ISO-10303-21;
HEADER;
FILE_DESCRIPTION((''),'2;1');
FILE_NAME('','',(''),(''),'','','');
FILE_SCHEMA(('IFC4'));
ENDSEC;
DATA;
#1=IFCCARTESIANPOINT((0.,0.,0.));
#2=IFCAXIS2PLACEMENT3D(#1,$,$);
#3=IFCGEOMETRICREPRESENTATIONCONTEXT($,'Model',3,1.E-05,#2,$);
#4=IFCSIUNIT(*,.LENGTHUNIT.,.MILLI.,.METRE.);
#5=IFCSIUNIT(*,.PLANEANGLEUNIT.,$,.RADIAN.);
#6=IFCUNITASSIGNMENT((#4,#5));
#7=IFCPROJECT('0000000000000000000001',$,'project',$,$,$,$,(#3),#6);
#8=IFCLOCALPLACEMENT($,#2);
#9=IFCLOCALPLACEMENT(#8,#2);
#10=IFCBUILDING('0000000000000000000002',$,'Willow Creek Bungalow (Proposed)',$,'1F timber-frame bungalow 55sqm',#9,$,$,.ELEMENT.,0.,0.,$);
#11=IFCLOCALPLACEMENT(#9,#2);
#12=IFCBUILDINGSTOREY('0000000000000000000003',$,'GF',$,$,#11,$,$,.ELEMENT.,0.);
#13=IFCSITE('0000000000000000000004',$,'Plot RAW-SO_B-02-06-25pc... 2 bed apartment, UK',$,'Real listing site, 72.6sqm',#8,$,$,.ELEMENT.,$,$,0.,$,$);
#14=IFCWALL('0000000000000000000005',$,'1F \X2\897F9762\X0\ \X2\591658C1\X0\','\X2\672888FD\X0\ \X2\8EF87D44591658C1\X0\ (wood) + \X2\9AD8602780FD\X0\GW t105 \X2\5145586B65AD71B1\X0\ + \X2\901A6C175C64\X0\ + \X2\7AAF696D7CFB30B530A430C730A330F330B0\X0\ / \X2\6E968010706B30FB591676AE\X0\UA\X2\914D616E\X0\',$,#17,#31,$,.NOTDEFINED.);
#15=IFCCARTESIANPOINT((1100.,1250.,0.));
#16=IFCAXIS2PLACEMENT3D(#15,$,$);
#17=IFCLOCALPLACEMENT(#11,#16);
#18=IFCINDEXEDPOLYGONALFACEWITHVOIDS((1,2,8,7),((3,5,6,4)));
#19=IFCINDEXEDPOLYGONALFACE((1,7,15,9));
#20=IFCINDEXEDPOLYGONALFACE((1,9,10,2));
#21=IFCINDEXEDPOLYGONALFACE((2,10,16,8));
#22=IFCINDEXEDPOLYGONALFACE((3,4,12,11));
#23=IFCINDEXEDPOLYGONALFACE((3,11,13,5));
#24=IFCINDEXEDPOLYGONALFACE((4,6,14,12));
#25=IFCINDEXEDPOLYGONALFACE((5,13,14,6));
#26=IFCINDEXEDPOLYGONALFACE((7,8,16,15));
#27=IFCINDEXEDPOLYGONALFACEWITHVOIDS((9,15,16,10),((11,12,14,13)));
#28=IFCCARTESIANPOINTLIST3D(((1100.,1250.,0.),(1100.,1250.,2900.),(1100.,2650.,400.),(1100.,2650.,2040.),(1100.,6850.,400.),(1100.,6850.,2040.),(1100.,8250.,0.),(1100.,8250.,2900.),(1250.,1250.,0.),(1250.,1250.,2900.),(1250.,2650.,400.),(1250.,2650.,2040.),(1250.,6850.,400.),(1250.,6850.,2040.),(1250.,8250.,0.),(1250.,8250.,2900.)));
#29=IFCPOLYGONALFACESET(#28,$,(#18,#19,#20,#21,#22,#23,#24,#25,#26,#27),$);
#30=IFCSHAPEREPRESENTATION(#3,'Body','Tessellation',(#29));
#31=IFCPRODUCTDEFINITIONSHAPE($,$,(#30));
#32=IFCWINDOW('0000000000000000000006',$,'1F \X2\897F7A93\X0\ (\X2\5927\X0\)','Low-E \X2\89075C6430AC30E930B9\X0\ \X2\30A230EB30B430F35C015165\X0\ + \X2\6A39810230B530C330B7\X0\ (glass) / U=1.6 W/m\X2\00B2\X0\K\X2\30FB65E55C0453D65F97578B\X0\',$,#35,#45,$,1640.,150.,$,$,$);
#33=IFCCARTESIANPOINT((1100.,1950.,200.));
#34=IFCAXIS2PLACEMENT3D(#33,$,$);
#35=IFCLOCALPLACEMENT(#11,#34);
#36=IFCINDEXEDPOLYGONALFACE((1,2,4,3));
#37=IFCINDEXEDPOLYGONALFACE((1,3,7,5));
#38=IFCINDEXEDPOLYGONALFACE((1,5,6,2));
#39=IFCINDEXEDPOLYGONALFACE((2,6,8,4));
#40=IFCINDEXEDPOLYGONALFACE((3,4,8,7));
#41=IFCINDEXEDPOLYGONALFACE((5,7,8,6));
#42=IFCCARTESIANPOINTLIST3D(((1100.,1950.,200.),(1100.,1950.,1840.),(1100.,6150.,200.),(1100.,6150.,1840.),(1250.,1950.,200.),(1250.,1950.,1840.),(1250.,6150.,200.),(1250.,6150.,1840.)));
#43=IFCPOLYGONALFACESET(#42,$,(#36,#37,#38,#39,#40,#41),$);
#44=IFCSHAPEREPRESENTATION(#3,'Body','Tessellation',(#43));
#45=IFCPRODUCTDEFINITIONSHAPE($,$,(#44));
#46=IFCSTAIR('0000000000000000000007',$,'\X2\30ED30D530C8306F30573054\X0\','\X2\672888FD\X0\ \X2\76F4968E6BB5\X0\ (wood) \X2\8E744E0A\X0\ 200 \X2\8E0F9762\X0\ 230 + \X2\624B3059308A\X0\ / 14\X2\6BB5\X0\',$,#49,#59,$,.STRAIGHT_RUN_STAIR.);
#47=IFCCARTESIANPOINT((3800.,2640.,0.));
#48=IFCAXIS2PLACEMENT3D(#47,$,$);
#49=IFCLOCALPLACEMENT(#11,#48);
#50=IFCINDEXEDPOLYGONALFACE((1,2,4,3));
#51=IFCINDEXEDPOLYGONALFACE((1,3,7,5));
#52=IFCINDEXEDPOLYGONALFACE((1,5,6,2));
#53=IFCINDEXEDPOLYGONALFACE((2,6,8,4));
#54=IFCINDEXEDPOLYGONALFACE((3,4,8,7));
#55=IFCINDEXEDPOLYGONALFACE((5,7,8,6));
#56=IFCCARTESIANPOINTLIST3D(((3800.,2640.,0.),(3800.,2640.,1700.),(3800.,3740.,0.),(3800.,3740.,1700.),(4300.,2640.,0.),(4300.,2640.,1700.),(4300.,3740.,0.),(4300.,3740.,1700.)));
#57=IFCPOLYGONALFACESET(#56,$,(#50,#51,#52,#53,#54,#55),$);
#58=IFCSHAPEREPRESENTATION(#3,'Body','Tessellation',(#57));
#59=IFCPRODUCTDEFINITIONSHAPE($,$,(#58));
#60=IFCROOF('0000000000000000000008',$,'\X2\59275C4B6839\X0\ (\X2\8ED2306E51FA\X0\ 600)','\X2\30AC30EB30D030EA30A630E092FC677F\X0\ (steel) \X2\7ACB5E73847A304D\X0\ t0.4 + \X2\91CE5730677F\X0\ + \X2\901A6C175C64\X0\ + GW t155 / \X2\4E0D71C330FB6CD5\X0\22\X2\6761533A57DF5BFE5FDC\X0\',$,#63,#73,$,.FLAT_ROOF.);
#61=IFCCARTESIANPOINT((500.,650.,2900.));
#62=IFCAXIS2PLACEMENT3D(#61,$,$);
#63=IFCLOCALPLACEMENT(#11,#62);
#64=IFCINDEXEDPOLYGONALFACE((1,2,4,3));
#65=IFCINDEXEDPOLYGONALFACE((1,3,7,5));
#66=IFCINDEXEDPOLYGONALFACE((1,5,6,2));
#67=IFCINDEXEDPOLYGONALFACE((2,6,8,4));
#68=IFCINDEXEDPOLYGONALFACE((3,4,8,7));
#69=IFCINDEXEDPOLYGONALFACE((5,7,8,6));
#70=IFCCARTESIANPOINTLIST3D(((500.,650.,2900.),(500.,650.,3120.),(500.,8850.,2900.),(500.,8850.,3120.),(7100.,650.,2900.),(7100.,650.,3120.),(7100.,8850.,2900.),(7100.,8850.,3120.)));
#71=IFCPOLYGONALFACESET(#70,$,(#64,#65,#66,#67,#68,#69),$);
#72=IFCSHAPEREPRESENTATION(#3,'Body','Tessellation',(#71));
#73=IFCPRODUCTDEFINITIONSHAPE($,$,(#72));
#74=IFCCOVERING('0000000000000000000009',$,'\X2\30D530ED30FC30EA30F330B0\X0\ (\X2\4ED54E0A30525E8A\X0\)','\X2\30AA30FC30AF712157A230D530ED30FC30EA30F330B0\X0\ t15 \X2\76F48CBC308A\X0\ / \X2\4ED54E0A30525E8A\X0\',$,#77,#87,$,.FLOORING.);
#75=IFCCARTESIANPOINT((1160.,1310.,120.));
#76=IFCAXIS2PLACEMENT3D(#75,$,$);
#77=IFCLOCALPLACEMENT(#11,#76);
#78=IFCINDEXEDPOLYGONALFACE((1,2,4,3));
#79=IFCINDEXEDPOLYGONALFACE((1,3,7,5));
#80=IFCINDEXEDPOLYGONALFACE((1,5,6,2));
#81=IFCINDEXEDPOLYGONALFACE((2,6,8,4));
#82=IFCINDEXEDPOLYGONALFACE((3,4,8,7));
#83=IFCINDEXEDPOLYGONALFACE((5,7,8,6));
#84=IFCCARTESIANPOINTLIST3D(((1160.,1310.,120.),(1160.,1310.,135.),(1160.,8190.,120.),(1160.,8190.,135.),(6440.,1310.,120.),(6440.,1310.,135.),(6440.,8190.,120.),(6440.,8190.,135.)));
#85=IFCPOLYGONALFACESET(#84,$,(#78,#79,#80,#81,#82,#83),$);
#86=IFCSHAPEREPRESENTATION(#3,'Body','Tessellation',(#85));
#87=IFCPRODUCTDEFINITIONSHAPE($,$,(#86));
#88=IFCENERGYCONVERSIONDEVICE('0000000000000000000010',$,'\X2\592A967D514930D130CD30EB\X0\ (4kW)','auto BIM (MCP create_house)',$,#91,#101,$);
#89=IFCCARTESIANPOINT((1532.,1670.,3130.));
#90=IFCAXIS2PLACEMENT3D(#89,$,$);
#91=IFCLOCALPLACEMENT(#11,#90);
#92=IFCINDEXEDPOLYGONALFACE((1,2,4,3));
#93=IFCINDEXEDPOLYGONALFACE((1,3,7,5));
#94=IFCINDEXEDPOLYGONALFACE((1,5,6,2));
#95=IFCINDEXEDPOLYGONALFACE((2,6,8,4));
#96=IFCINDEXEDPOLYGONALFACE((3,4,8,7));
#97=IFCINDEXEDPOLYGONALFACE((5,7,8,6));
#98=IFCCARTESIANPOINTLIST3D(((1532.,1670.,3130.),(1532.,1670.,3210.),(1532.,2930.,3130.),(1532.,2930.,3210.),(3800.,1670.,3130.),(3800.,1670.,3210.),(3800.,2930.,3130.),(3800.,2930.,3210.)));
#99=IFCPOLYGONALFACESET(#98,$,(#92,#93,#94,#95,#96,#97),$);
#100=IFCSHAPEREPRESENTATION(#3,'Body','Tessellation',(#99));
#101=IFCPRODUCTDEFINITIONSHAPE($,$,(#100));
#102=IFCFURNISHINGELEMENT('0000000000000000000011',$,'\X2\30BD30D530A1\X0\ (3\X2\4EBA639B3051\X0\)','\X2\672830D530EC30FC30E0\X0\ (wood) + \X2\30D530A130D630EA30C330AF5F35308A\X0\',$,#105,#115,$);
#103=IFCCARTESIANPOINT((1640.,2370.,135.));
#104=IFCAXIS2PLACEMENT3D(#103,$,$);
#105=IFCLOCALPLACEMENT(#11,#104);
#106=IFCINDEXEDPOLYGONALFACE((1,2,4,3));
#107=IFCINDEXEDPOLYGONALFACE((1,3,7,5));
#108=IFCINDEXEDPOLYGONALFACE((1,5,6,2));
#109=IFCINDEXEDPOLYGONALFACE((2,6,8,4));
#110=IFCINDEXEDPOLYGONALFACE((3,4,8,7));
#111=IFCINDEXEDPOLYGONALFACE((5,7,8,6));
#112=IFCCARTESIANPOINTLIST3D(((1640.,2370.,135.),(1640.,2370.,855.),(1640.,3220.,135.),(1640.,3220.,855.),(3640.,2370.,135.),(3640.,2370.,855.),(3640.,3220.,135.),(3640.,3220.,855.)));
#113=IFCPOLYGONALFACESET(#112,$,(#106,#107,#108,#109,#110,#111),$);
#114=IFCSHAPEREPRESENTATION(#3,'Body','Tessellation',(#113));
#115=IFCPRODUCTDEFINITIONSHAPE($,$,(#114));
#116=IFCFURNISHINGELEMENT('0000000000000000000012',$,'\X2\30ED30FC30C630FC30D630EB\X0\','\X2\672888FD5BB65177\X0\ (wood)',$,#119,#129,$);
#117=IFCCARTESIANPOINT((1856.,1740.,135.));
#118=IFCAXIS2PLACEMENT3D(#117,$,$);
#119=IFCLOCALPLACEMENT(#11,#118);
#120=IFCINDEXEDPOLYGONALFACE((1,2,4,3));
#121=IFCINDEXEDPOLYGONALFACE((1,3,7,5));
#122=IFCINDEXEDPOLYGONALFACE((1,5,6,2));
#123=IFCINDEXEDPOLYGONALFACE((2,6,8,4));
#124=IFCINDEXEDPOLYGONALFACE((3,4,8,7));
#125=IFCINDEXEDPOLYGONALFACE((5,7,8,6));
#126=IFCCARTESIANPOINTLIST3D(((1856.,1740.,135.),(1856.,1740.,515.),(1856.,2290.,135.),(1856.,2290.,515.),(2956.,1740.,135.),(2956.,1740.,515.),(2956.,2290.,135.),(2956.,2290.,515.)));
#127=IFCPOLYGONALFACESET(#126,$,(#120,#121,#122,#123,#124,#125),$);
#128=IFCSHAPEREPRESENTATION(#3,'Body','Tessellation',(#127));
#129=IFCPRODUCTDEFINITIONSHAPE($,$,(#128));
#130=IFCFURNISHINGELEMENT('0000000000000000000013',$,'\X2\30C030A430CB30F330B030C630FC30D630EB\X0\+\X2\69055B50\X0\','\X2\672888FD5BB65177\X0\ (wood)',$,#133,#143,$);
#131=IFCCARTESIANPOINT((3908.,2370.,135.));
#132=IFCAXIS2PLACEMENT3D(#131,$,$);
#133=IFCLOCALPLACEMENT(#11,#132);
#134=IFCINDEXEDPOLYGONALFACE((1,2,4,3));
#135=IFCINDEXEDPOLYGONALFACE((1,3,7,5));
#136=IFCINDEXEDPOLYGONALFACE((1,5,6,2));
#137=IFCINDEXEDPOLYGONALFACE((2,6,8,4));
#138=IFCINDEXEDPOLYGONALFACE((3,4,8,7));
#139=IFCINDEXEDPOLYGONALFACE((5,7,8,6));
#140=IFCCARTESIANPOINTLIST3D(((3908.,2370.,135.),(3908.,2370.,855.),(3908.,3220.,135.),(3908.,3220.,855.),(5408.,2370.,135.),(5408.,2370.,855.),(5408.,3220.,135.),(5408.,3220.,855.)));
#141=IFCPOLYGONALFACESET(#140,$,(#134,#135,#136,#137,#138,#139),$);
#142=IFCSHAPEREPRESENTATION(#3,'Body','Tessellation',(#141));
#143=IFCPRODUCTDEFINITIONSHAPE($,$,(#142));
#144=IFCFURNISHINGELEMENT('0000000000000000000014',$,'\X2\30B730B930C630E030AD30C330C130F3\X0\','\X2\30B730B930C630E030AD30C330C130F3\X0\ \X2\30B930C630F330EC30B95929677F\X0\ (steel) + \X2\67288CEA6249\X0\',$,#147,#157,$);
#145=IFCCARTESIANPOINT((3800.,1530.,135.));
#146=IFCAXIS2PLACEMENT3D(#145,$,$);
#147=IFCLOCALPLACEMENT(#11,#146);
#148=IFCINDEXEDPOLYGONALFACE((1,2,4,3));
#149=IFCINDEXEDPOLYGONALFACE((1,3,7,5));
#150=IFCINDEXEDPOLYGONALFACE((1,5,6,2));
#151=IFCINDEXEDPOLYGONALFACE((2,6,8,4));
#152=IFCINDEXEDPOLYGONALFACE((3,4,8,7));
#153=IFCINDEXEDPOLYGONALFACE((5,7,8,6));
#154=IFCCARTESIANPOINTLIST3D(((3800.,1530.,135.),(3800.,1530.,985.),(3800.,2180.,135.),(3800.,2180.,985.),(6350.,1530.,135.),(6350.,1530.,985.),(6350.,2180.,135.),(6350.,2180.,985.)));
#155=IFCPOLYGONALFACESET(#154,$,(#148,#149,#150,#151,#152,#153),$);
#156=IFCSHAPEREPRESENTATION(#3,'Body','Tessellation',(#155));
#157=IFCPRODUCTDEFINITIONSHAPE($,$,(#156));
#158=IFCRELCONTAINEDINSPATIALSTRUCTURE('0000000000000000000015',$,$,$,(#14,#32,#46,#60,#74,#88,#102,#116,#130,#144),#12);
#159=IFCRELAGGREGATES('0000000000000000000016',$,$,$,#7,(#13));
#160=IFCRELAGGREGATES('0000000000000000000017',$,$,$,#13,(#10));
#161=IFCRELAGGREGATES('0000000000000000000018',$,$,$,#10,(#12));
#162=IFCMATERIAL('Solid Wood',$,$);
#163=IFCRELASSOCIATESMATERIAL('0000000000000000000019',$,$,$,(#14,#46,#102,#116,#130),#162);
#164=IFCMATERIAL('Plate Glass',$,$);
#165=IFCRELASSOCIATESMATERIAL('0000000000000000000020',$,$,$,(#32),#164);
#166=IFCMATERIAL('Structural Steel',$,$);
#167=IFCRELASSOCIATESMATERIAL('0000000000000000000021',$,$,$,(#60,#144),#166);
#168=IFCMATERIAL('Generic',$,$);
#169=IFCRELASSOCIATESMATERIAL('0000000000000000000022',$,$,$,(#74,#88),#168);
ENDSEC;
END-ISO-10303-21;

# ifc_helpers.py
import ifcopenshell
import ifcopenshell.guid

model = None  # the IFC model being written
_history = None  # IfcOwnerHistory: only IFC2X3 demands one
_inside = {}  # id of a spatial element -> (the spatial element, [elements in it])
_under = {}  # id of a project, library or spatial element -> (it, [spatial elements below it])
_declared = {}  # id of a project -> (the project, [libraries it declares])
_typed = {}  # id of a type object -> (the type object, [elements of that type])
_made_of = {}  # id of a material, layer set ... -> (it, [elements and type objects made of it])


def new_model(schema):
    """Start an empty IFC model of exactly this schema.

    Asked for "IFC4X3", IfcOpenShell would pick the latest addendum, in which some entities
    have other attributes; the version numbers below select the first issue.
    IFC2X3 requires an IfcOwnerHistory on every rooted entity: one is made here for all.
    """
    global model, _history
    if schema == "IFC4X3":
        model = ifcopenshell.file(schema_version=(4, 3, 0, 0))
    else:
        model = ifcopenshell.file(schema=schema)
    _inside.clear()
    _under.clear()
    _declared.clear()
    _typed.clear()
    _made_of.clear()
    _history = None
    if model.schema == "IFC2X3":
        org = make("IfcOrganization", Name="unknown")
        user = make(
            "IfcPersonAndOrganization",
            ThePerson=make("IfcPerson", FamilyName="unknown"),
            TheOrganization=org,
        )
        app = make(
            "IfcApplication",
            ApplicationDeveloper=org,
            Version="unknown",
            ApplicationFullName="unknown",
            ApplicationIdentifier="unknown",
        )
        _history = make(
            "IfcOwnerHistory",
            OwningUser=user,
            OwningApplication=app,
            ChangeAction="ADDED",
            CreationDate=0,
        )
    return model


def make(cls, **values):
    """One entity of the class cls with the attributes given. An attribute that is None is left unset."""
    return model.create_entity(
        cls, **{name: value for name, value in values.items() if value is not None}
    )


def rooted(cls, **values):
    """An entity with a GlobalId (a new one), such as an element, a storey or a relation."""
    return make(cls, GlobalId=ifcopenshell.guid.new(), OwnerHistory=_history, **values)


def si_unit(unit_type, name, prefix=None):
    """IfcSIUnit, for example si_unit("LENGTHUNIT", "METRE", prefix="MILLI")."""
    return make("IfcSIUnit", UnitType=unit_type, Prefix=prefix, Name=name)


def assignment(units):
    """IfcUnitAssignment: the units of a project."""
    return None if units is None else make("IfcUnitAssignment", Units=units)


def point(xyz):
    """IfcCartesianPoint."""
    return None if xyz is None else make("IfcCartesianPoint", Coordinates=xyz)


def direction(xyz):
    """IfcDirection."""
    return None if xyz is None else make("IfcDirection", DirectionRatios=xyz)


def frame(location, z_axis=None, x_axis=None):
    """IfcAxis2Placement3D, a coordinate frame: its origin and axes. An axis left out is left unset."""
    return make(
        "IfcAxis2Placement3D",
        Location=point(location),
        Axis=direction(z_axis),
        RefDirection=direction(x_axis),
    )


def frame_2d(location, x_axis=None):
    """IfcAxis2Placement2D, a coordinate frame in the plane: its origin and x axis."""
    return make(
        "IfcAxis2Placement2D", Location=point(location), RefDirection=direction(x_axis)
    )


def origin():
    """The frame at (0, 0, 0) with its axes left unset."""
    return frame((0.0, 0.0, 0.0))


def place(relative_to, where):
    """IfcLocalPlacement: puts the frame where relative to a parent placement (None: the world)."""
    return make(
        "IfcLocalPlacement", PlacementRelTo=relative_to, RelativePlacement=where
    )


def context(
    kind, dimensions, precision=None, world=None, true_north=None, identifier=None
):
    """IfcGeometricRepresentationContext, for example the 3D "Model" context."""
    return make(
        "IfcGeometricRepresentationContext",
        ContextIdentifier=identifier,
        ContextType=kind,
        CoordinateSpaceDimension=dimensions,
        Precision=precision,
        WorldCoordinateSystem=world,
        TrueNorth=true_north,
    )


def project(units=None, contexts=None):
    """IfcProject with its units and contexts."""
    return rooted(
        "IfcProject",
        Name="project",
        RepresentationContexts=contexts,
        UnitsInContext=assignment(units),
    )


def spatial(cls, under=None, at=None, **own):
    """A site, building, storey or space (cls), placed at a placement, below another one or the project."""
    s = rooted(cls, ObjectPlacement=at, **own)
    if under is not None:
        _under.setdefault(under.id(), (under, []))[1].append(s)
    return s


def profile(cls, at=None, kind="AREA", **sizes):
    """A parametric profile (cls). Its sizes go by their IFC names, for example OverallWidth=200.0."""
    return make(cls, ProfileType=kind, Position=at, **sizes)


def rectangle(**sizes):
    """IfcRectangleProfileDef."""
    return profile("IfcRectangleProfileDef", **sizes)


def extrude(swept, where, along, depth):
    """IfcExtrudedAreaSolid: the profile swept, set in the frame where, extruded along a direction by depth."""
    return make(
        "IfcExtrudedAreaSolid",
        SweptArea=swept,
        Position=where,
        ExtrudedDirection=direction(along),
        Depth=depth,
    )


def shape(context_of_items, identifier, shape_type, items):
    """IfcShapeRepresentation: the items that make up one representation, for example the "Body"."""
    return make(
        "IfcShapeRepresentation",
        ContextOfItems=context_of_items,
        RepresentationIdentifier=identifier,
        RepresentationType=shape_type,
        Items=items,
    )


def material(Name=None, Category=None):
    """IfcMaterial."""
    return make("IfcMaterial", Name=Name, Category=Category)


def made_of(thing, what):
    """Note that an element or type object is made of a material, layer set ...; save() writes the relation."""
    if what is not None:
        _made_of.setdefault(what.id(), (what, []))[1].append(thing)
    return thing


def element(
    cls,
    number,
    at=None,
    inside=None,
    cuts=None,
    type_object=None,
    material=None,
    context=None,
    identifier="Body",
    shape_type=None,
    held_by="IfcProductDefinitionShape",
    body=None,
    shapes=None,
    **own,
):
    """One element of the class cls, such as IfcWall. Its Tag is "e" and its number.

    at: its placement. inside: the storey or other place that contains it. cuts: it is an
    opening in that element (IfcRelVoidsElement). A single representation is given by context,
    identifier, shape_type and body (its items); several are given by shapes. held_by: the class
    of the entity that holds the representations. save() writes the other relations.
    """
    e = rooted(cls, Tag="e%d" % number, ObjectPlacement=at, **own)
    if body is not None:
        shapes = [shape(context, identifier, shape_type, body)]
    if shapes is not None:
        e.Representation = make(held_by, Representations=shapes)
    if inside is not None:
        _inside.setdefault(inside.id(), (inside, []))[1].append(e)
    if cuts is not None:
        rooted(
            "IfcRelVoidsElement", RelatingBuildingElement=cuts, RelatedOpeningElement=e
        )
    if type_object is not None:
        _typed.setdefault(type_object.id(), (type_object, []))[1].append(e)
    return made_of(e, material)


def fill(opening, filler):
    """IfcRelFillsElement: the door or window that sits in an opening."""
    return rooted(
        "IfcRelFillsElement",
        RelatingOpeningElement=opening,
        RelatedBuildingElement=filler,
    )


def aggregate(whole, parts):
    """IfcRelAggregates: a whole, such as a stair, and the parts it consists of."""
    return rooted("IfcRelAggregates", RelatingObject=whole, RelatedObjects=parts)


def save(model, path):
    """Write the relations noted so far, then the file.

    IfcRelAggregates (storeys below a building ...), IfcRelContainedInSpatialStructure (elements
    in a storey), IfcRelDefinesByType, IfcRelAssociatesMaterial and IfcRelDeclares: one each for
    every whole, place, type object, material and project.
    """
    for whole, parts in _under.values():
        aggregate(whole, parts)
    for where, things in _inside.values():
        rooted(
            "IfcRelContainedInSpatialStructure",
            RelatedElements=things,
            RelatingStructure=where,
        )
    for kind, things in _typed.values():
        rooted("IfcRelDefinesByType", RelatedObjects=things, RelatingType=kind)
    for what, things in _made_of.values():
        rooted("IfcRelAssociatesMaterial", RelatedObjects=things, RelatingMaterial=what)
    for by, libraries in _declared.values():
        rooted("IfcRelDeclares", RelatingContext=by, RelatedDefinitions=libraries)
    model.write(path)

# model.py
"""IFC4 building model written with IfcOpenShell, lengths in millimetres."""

from ifc_helpers import new_model, si_unit, frame, frame_2d, origin, place, context, project, spatial, rectangle, extrude, material, element, fill, save


model = new_model("IFC4")

# Units and contexts
model_context = context("Model", 3, precision=1e-05, world=origin())
ifc_project = project(units=[si_unit("LENGTHUNIT", "METRE", prefix="MILLI"), si_unit("PLANEANGLEUNIT", "RADIAN")], contexts=[model_context])

# Site, building, storey
site_placement = place(None, origin())
site = spatial("IfcSite", under=ifc_project, at=site_placement, Name="Plot RAW-SO_B-02-06-25pc... 2 bed apartment, UK", ObjectType="Real listing site, 72.6sqm", CompositionType="ELEMENT", RefElevation=0.0)
building_placement = place(site_placement, origin())
building = spatial("IfcBuilding", under=site, at=building_placement, Name="Willow Creek Bungalow (Proposed)", ObjectType="1F timber-frame bungalow 55sqm", CompositionType="ELEMENT", ElevationOfRefHeight=0.0, ElevationOfTerrain=0.0)
storey_placement = place(building_placement, origin())
storey = spatial("IfcBuildingStorey", under=building, at=storey_placement, Name="GF", CompositionType="ELEMENT", Elevation=0.0)

# Shared definitions
ifc_material_1 = material(Name="Solid Wood")
ifc_material_2 = material(Name="Generic")

# Shared definitions
ifc_material_3 = material(Name="Plate Glass")

# Wall, opening, window
wall_1_placement = place(storey_placement, frame((1100.0, 1250.0, 0.0)))
wall_1 = element("IfcWall", 1, at=wall_1_placement, inside=storey, material=ifc_material_1, Name="1F 西面 外壁", Description="木製 軸組外壁 (wood) + 高性能GW t105 充填断熱 + 通気層 + 窯業系サイディング / 準耐火・外皮UA配慮", PredefinedType="NOTDEFINED", context=model_context, shape_type="SweptSolid", body=[
    extrude(rectangle(XDim=150.0, YDim=7000.0, at=frame_2d((75.0, 3500.0))), frame((1100.0, 1250.0, 0.0)), (0.0, 0.0, 1.0), 2900.0),
])
opening_1_placement = place(storey_placement, frame((1100.0, 1950.0, 200.0)))
opening_1 = element("IfcOpeningElement", 2, at=opening_1_placement, cuts=wall_1, PredefinedType="NOTDEFINED", context=model_context, shape_type="SweptSolid", body=[
    extrude(rectangle(XDim=150.0, YDim=4200.0, at=frame_2d((75.0, 2100.0))), frame((1100.0, 1950.0, 200.0)), (0.0, 0.0, 1.0), 1640.0),
])
window_1_placement = place(storey_placement, frame((1100.0, 1950.0, 200.0)))
window_1 = element("IfcWindow", 3, at=window_1_placement, inside=storey, material=ifc_material_3, Name="1F 西窓 (大)", Description="Low-E 複層ガラス アルゴン封入 + 樹脂サッシ (glass) / U=1.6 W/m²K・日射取得型", OverallHeight=1640.0, OverallWidth=150.0, context=model_context, shape_type="SweptSolid", body=[
    extrude(rectangle(XDim=150.0, YDim=4200.0, at=frame_2d((75.0, 2100.0))), frame((1100.0, 1950.0, 200.0)), (0.0, 0.0, 1.0), 1640.0),
])
fill(opening_1, window_1)

# Stair
stair_placement = place(storey_placement, frame((3800.0, 2640.0, 0.0)))
element("IfcStair", 4, at=stair_placement, inside=storey, material=ifc_material_1, Name="ロフトはしご", Description="木製 直階段 (wood) 蹴上 200 踏面 230 + 手すり / 14段", PredefinedType="STRAIGHT_RUN_STAIR", context=model_context, shape_type="SweptSolid", body=[
    extrude(rectangle(XDim=500.0, YDim=1100.0, at=frame_2d((250.0, 550.0))), frame((3800.0, 2640.0, 0.0)), (0.0, 0.0, 1.0), 1700.0),
])

# Roof
ifc_material_4 = material(Name="Structural Steel")
roof_placement = place(storey_placement, frame((500.0, 650.0, 2900.0)))
element("IfcRoof", 5, at=roof_placement, inside=storey, material=ifc_material_4, Name="大屋根 (軒の出 600)", Description="ガルバリウム鋼板 (steel) 立平葺き t0.4 + 野地板 + 通気層 + GW t155 / 不燃・法22条区域対応", PredefinedType="FLAT_ROOF", context=model_context, shape_type="SweptSolid", body=[
    extrude(rectangle(XDim=6600.0, YDim=8200.0, at=frame_2d((3300.0, 4100.0))), frame((500.0, 650.0, 2900.0)), (0.0, 0.0, 1.0), 220.0),
])

# Covering
covering_placement = place(storey_placement, frame((1160.0, 1310.0, 120.0)))
element("IfcCovering", 6, at=covering_placement, inside=storey, material=ifc_material_2, Name="フローリング (仕上げ床)", Description="オーク無垢フローリング t15 直貼り / 仕上げ床", PredefinedType="FLOORING", context=model_context, shape_type="SweptSolid", body=[
    extrude(rectangle(XDim=5280.0, YDim=6880.0, at=frame_2d((2640.0, 3440.0))), frame((1160.0, 1310.0, 120.0)), (0.0, 0.0, 1.0), 15.0),
])

# Energy conversion device
energy_conversion_device_placement = place(storey_placement, frame((1532.0, 1670.0, 3130.0)))
element("IfcEnergyConversionDevice", 7, at=energy_conversion_device_placement, inside=storey, material=ifc_material_2, Name="太陽光パネル (4kW)", Description="auto BIM (MCP create_house)", context=model_context, shape_type="SweptSolid", body=[
    extrude(rectangle(XDim=2268.0, YDim=1260.0, at=frame_2d((1134.0, 630.0))), frame((1532.0, 1670.0, 3130.0)), (0.0, 0.0, 1.0), 80.0),
])

# Furnishing elements
furnishing_1_placement = place(storey_placement, frame((1640.0, 2370.0, 135.0)))
element("IfcFurnishingElement", 8, at=furnishing_1_placement, inside=storey, material=ifc_material_1, Name="ソファ (3人掛け)", Description="木フレーム (wood) + ファブリック張り", context=model_context, shape_type="SweptSolid", body=[
    extrude(rectangle(XDim=2000.0, YDim=850.0, at=frame_2d((1000.0, 425.0))), frame((1640.0, 2370.0, 135.0)), (0.0, 0.0, 1.0), 720.0),
])
furnishing_2_placement = place(storey_placement, frame((1856.0, 1740.0, 135.0)))
element("IfcFurnishingElement", 9, at=furnishing_2_placement, inside=storey, material=ifc_material_1, Name="ローテーブル", Description="木製家具 (wood)", context=model_context, shape_type="SweptSolid", body=[
    extrude(rectangle(XDim=1100.0, YDim=550.0, at=frame_2d((550.0, 275.0))), frame((1856.0, 1740.0, 135.0)), (0.0, 0.0, 1.0), 380.0),
])
furnishing_3_placement = place(storey_placement, frame((3908.0, 2370.0, 135.0)))
element("IfcFurnishingElement", 10, at=furnishing_3_placement, inside=storey, material=ifc_material_1, Name="ダイニングテーブル+椅子", Description="木製家具 (wood)", context=model_context, shape_type="SweptSolid", body=[
    extrude(rectangle(XDim=1500.0, YDim=850.0, at=frame_2d((750.0, 425.0))), frame((3908.0, 2370.0, 135.0)), (0.0, 0.0, 1.0), 720.0),
])
furnishing_4_placement = place(storey_placement, frame((3800.0, 1530.0, 135.0)))
element("IfcFurnishingElement", 11, at=furnishing_4_placement, inside=storey, material=ifc_material_4, Name="システムキッチン", Description="システムキッチン ステンレス天板 (steel) + 木質扉", context=model_context, shape_type="SweptSolid", body=[
    extrude(rectangle(XDim=2550.0, YDim=650.0, at=frame_2d((1275.0, 325.0))), frame((3800.0, 1530.0, 135.0)), (0.0, 0.0, 1.0), 850.0),
])

save(model, "model.ifc")
